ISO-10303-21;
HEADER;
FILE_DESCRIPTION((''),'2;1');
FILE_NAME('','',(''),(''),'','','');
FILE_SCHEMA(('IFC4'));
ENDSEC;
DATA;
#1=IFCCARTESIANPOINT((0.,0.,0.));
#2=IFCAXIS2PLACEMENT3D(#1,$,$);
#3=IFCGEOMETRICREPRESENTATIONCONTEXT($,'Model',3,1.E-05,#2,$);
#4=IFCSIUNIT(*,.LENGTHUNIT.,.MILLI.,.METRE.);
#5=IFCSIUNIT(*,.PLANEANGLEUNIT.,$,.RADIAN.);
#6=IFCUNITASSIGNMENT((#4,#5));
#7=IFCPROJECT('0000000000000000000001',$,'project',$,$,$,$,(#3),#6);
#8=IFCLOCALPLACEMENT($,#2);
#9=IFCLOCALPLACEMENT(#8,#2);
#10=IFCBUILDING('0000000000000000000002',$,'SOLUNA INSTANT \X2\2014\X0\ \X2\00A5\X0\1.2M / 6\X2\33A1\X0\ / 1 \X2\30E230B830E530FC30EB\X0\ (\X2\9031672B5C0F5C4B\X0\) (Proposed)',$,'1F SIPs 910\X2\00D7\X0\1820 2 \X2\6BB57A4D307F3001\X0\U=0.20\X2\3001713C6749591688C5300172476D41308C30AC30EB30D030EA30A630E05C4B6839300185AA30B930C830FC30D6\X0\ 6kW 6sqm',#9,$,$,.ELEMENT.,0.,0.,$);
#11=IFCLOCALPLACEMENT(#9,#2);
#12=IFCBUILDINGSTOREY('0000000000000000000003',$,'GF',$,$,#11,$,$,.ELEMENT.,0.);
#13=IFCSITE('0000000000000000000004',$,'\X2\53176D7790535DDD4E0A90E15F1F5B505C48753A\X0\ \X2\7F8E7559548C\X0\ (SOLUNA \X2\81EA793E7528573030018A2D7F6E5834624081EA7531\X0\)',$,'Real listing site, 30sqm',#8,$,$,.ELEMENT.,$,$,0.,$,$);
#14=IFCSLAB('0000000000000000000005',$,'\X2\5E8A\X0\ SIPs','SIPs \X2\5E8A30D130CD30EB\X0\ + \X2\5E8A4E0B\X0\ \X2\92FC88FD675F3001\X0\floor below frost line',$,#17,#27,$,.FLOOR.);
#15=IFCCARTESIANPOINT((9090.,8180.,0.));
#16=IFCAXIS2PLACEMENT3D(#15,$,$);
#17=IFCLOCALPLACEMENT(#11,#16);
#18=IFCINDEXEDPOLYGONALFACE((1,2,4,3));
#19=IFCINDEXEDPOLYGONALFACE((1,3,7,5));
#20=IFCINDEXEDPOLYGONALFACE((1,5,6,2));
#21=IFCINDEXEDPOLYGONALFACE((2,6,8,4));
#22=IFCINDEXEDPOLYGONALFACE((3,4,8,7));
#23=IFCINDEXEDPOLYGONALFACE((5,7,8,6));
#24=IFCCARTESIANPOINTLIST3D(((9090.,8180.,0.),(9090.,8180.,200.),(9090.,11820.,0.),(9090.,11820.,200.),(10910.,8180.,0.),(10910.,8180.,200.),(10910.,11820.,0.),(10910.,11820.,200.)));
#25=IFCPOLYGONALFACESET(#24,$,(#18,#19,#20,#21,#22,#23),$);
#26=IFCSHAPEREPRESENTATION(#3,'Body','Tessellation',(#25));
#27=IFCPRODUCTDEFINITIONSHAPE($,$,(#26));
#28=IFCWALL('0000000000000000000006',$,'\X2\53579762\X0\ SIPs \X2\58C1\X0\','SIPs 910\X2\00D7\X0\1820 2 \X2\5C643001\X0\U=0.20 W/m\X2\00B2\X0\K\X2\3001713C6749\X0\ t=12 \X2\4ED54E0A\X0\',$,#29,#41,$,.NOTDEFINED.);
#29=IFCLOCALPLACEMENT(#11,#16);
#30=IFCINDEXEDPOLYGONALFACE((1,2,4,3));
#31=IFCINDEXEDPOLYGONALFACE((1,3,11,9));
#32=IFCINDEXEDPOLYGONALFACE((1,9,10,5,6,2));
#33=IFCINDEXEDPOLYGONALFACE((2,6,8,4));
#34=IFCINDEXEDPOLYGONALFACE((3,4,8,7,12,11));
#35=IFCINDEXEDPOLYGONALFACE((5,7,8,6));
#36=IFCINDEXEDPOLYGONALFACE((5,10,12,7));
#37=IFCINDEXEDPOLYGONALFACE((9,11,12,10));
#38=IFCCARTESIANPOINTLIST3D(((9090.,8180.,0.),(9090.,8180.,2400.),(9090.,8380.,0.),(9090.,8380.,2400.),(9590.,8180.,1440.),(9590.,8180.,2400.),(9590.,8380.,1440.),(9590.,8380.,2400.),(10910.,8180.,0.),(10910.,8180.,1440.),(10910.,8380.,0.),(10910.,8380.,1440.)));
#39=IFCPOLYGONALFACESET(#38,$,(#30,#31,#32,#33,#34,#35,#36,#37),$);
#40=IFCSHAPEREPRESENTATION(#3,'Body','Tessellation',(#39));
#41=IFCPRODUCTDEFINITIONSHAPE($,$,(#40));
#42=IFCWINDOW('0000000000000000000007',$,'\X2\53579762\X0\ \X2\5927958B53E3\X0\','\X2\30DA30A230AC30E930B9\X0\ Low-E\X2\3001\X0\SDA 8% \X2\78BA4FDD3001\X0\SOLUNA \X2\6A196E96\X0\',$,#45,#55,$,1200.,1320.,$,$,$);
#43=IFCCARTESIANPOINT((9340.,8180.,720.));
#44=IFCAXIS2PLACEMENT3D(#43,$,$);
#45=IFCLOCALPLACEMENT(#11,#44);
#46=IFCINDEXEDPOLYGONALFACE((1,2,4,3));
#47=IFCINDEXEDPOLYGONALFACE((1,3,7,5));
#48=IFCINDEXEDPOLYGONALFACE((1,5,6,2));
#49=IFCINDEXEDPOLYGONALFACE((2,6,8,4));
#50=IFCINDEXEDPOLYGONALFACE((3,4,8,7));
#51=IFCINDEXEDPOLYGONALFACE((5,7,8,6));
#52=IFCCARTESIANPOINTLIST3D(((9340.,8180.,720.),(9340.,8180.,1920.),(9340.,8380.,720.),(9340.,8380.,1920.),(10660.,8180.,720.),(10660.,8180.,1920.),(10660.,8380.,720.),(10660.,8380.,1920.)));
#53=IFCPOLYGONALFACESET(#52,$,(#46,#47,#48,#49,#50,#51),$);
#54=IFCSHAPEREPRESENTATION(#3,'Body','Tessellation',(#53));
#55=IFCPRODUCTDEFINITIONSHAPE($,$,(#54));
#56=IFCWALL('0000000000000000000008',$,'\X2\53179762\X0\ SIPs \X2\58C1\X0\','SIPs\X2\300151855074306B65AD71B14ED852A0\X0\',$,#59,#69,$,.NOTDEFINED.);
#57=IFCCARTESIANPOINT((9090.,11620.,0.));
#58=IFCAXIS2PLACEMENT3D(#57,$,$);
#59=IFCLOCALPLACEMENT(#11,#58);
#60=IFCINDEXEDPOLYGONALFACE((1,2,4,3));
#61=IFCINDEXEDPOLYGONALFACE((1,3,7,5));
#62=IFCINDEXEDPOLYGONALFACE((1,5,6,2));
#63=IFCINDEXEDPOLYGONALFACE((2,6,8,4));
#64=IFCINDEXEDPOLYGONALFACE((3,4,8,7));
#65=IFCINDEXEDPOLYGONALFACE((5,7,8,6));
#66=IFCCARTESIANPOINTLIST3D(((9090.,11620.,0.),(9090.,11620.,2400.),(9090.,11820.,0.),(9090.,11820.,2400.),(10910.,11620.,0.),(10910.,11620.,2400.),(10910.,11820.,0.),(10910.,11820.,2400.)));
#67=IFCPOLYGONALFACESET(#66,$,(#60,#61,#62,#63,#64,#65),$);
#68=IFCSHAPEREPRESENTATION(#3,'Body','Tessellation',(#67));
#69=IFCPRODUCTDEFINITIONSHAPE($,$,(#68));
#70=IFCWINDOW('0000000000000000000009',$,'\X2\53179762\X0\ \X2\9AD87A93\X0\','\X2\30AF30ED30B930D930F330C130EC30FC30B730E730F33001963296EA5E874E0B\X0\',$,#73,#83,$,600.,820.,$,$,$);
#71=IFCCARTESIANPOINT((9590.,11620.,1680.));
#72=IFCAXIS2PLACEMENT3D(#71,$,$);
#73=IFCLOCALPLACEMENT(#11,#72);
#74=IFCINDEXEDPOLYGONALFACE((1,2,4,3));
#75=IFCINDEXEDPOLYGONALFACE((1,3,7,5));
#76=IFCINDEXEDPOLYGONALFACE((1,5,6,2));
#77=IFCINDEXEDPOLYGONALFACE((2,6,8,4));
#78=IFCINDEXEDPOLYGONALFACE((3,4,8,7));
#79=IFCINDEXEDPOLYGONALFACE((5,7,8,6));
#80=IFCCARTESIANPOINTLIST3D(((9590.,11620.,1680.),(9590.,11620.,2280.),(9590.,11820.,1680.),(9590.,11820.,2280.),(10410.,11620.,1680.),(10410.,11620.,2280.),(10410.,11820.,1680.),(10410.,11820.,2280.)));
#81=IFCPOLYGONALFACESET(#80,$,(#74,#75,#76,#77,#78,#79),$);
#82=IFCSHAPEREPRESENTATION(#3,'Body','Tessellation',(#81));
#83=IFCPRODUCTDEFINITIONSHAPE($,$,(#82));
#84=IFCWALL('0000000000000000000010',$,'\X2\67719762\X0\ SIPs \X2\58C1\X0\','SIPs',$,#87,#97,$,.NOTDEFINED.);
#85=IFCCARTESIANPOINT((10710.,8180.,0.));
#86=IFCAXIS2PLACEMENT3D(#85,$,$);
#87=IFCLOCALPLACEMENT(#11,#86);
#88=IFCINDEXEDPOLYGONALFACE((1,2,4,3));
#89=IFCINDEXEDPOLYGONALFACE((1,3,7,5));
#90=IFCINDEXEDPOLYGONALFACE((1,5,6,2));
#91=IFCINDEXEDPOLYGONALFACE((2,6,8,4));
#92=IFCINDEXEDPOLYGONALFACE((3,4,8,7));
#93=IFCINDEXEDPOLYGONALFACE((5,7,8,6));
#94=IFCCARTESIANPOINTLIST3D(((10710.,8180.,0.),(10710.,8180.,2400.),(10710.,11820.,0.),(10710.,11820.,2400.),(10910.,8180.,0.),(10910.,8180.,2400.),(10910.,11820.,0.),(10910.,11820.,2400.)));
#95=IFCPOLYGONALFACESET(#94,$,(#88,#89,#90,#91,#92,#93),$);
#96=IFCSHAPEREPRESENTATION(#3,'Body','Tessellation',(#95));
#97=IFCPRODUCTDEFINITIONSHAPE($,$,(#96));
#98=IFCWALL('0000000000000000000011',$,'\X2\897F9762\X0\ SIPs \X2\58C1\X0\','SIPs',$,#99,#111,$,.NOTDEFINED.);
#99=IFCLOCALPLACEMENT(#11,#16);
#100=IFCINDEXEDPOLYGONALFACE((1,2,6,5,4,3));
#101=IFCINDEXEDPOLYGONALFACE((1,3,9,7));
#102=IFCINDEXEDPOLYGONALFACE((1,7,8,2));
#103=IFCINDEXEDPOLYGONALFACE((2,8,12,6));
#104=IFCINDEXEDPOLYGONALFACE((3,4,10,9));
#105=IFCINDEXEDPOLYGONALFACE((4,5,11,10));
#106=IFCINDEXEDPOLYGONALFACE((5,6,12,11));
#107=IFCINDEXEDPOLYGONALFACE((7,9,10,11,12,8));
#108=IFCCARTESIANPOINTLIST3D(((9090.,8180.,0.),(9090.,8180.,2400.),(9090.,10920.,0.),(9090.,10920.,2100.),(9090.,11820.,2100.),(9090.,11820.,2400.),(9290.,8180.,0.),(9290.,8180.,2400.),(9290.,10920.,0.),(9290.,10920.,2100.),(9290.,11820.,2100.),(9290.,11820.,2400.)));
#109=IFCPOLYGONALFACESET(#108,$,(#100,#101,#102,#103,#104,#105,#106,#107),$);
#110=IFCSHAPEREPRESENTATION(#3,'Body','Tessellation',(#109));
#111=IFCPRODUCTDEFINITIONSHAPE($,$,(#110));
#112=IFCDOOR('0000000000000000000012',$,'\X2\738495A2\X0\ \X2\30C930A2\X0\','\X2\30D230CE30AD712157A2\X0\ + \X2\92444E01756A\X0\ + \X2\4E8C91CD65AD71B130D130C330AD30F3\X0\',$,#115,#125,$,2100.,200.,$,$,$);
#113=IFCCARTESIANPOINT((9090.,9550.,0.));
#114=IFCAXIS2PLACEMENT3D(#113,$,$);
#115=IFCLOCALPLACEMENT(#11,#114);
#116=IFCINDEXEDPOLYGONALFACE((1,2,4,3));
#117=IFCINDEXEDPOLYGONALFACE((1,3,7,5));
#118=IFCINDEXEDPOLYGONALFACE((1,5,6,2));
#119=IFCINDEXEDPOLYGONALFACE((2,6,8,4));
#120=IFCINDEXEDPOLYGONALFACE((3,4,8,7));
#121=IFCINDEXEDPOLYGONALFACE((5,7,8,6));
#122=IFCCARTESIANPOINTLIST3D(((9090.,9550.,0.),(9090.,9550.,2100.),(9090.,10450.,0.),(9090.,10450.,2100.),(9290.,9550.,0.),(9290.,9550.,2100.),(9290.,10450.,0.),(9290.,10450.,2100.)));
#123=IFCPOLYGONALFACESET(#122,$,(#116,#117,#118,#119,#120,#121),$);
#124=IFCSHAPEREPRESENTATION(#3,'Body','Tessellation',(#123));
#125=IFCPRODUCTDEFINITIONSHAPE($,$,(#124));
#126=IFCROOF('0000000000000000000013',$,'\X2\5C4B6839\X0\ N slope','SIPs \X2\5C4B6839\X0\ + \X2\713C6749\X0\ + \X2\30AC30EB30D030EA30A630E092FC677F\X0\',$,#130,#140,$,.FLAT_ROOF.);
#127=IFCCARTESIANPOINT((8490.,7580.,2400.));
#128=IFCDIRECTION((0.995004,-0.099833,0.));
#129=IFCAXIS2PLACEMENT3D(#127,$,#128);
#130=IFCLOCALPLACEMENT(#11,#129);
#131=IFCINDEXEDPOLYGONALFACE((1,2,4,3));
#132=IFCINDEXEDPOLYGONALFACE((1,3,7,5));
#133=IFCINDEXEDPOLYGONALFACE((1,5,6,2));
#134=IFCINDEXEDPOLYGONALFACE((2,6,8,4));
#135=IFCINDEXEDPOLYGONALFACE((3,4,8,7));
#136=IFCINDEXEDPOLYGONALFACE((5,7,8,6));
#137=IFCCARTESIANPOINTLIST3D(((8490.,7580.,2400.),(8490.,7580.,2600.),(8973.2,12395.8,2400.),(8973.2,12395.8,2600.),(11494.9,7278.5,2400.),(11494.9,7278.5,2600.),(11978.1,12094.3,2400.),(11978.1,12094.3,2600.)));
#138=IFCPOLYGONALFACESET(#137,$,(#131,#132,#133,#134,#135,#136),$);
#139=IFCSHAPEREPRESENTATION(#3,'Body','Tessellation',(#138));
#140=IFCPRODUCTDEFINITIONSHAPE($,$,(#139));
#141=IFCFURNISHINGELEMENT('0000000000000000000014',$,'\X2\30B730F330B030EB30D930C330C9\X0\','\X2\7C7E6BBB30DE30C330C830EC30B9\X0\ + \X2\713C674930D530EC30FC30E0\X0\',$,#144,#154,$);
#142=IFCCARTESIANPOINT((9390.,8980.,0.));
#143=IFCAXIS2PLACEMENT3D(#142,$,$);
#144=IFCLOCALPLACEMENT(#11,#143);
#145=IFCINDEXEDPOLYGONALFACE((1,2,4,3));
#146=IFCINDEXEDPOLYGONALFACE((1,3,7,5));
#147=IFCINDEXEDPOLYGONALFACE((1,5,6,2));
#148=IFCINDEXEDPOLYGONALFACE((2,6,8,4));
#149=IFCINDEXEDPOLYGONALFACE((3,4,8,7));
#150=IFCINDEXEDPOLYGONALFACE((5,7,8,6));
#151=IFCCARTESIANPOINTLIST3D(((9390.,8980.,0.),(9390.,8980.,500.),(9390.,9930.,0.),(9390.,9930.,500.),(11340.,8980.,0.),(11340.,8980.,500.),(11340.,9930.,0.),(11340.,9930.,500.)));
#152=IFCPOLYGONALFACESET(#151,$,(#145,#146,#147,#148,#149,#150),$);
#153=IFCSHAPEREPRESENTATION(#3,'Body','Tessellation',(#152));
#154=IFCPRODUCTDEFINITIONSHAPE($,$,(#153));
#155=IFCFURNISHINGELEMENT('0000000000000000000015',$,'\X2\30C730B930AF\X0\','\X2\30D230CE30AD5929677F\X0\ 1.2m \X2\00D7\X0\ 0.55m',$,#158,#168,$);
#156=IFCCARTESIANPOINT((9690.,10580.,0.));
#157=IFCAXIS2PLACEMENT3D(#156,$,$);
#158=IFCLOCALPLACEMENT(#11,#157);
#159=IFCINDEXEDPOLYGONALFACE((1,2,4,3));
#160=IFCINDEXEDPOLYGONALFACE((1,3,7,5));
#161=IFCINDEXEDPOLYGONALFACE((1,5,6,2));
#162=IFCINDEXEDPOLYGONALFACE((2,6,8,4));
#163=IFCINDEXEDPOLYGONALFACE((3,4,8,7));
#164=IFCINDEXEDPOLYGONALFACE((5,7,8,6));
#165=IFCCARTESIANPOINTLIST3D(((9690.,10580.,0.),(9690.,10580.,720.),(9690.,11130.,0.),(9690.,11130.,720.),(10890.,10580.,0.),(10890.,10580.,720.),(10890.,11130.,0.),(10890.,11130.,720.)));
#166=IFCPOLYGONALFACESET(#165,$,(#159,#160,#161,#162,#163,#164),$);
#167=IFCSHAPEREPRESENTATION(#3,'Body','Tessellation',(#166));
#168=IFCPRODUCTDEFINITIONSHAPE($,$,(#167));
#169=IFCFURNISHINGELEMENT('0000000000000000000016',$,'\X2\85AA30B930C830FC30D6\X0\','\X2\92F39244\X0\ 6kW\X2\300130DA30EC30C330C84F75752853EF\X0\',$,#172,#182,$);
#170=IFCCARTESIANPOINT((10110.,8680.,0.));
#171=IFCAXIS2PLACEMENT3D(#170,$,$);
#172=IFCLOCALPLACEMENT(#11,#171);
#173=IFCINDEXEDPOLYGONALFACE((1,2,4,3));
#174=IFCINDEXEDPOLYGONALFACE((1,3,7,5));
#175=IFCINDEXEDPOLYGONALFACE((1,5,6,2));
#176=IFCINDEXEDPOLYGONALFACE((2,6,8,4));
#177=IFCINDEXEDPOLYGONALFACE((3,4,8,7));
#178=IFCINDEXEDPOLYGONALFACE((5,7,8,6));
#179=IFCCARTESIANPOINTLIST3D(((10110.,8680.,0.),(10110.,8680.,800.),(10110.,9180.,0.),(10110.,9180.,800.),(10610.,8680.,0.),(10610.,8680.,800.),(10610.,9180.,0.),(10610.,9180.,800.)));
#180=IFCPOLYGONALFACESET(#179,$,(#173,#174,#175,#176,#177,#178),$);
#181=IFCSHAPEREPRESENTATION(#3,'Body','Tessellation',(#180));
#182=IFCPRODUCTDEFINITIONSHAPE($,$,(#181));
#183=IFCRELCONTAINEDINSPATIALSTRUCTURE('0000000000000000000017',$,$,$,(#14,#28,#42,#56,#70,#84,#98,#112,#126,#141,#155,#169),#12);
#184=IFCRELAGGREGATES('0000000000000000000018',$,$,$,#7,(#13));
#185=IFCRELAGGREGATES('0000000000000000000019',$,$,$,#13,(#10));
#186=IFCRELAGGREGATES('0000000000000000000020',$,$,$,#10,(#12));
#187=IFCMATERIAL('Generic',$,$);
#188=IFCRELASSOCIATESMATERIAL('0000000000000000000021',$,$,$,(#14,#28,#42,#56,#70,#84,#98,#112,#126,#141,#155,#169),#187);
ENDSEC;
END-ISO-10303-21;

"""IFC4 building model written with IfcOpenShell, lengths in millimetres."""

from ifc_helpers import new_model, si_unit, frame, frame_2d, origin, place, context, project, spatial, rectangle, extrude, material, element, fill, save


model = new_model("IFC4")

# Units and contexts
model_context = context("Model", 3, precision=1e-05, world=origin())
ifc_project = project(units=[si_unit("LENGTHUNIT", "METRE", prefix="MILLI"), si_unit("PLANEANGLEUNIT", "RADIAN")], contexts=[model_context])

# Site, building, storey
site_placement = place(None, origin())
site = spatial("IfcSite", under=ifc_project, at=site_placement, Name="北海道川上郡弟子屈町 美留和 (SOLUNA 自社用地、設置場所自由)", ObjectType="Real listing site, 30sqm", CompositionType="ELEMENT", RefElevation=0.0)
building_placement = place(site_placement, origin())
building = spatial("IfcBuilding", under=site, at=building_placement, Name="SOLUNA INSTANT — ¥1.2M / 6㎡ / 1 モジュール (週末小屋) (Proposed)", ObjectType="1F SIPs 910×1820 2 段積み、U=0.20、焼杉外装、片流れガルバリウム屋根、薪ストーブ 6kW 6sqm", CompositionType="ELEMENT", ElevationOfRefHeight=0.0, ElevationOfTerrain=0.0)
storey_placement = place(building_placement, origin())
storey = spatial("IfcBuildingStorey", under=building, at=storey_placement, Name="GF", CompositionType="ELEMENT", Elevation=0.0)

# Slab
ifc_material = material(Name="Generic")
slab_placement = place(storey_placement, frame((9090.0, 8180.0, 0.0)))
element("IfcSlab", 1, at=slab_placement, inside=storey, material=ifc_material, Name="床 SIPs", Description="SIPs 床パネル + 床下 鋼製束、floor below frost line", PredefinedType="FLOOR", context=model_context, shape_type="SweptSolid", body=[
    extrude(rectangle(XDim=1820.0, YDim=3640.0, at=frame_2d((910.0, 1820.0))), frame((9090.0, 8180.0, 0.0)), (0.0, 0.0, 1.0), 200.0),
])

# Walls, openings, windows
wall_1_placement = place(storey_placement, frame((9090.0, 8180.0, 0.0)))
wall_1 = element("IfcWall", 2, at=wall_1_placement, inside=storey, material=ifc_material, Name="南面 SIPs 壁", Description="SIPs 910×1820 2 層、U=0.20 W/m²K、焼杉 t=12 仕上", PredefinedType="NOTDEFINED", context=model_context, shape_type="SweptSolid", body=[
    extrude(rectangle(XDim=1820.0, YDim=200.0, at=frame_2d((910.0, 100.0))), frame((9090.0, 8180.0, 0.0)), (0.0, 0.0, 1.0), 2400.0),
])
opening_1_placement = place(storey_placement, frame((9340.0, 8180.0, 720.0)))
opening_1 = element("IfcOpeningElement", 3, at=opening_1_placement, cuts=wall_1, PredefinedType="NOTDEFINED", context=model_context, shape_type="SweptSolid", body=[
    extrude(rectangle(XDim=1320.0, YDim=200.0, at=frame_2d((660.0, 100.0))), frame((9340.0, 8180.0, 720.0)), (0.0, 0.0, 1.0), 1200.0),
])
window_1_placement = place(storey_placement, frame((9340.0, 8180.0, 720.0)))
window_1 = element("IfcWindow", 4, at=window_1_placement, inside=storey, material=ifc_material, Name="南面 大開口", Description="ペアガラス Low-E、SDA 8% 確保、SOLUNA 標準", OverallHeight=1200.0, OverallWidth=1320.0, context=model_context, shape_type="SweptSolid", body=[
    extrude(rectangle(XDim=1320.0, YDim=200.0, at=frame_2d((660.0, 100.0))), frame((9340.0, 8180.0, 720.0)), (0.0, 0.0, 1.0), 1200.0),
])
fill(opening_1, window_1)
wall_2_placement = place(storey_placement, frame((9090.0, 11620.0, 0.0)))
wall_2 = element("IfcWall", 5, at=wall_2_placement, inside=storey, material=ifc_material, Name="北面 SIPs 壁", Description="SIPs、内側に断熱付加", PredefinedType="NOTDEFINED", context=model_context, shape_type="SweptSolid", body=[
    extrude(rectangle(XDim=1820.0, YDim=200.0, at=frame_2d((910.0, 100.0))), frame((9090.0, 11620.0, 0.0)), (0.0, 0.0, 1.0), 2400.0),
])
opening_2_placement = place(storey_placement, frame((9590.0, 11620.0, 1680.0)))
opening_2 = element("IfcOpeningElement", 6, at=opening_2_placement, cuts=wall_2, PredefinedType="NOTDEFINED", context=model_context, shape_type="SweptSolid", body=[
    extrude(rectangle(XDim=820.0, YDim=200.0, at=frame_2d((410.0, 100.0))), frame((9590.0, 11620.0, 1680.0)), (0.0, 0.0, 1.0), 600.0),
])
window_2_placement = place(storey_placement, frame((9590.0, 11620.0, 1680.0)))
window_2 = element("IfcWindow", 7, at=window_2_placement, inside=storey, material=ifc_material, Name="北面 高窓", Description="クロスベンチレーション、防雪庇下", OverallHeight=600.0, OverallWidth=820.0, context=model_context, shape_type="SweptSolid", body=[
    extrude(rectangle(XDim=820.0, YDim=200.0, at=frame_2d((410.0, 100.0))), frame((9590.0, 11620.0, 1680.0)), (0.0, 0.0, 1.0), 600.0),
])
fill(opening_2, window_2)

# Wall
wall_3_placement = place(storey_placement, frame((10710.0, 8180.0, 0.0)))
element("IfcWall", 8, at=wall_3_placement, inside=storey, material=ifc_material, Name="東面 SIPs 壁", Description="SIPs", PredefinedType="NOTDEFINED", context=model_context, shape_type="SweptSolid", body=[
    extrude(rectangle(XDim=200.0, YDim=3640.0, at=frame_2d((100.0, 1820.0))), frame((10710.0, 8180.0, 0.0)), (0.0, 0.0, 1.0), 2400.0),
])

# Wall, opening, door
wall_4_placement = place(storey_placement, frame((9090.0, 8180.0, 0.0)))
wall_4 = element("IfcWall", 9, at=wall_4_placement, inside=storey, material=ifc_material, Name="西面 SIPs 壁", Description="SIPs", PredefinedType="NOTDEFINED", context=model_context, shape_type="SweptSolid", body=[
    extrude(rectangle(XDim=200.0, YDim=3640.0, at=frame_2d((100.0, 1820.0))), frame((9090.0, 8180.0, 0.0)), (0.0, 0.0, 1.0), 2400.0),
])
opening_3_placement = place(storey_placement, frame((9090.0, 9550.0, 0.0)))
opening_3 = element("IfcOpeningElement", 10, at=opening_3_placement, cuts=wall_4, PredefinedType="NOTDEFINED", context=model_context, shape_type="SweptSolid", body=[
    extrude(rectangle(XDim=200.0, YDim=900.0, at=frame_2d((100.0, 450.0))), frame((9090.0, 9550.0, 0.0)), (0.0, 0.0, 1.0), 2100.0),
])
door_placement = place(storey_placement, frame((9090.0, 9550.0, 0.0)))
door = element("IfcDoor", 11, at=door_placement, inside=storey, material=ifc_material, Name="玄関 ドア", Description="ヒノキ無垢 + 鉄丁番 + 二重断熱パッキン", OverallHeight=2100.0, OverallWidth=200.0, context=model_context, shape_type="SweptSolid", body=[
    extrude(rectangle(XDim=200.0, YDim=900.0, at=frame_2d((100.0, 450.0))), frame((9090.0, 9550.0, 0.0)), (0.0, 0.0, 1.0), 2100.0),
])
fill(opening_3, door)

# Roof
roof_placement = place(storey_placement, frame((8490.0, 7580.0, 2400.0), x_axis=(0.995004, -0.099833, 0.0)))
element("IfcRoof", 12, at=roof_placement, inside=storey, material=ifc_material, Name="屋根 N slope", Description="SIPs 屋根 + 焼杉 + ガルバリウム鋼板", PredefinedType="FLAT_ROOF", context=model_context, shape_type="SweptSolid", body=[
    extrude(rectangle(XDim=3020.0, YDim=4840.0, at=frame_2d((1510.0, 2420.0))), frame((8490.0, 7580.0, 2400.0), x_axis=(0.995004, -0.099833, 0.0)), (0.0, 0.0, 1.0), 200.0),
])

# Furnishing elements
furnishing_1_placement = place(storey_placement, frame((9390.0, 8980.0, 0.0)))
element("IfcFurnishingElement", 13, at=furnishing_1_placement, inside=storey, material=ifc_material, Name="シングルベッド", Description="籾殻マットレス + 焼杉フレーム", context=model_context, shape_type="SweptSolid", body=[
    extrude(rectangle(XDim=1950.0, YDim=950.0, at=frame_2d((975.0, 475.0))), frame((9390.0, 8980.0, 0.0)), (0.0, 0.0, 1.0), 500.0),
])
furnishing_2_placement = place(storey_placement, frame((9690.0, 10580.0, 0.0)))
element("IfcFurnishingElement", 14, at=furnishing_2_placement, inside=storey, material=ifc_material, Name="デスク", Description="ヒノキ天板 1.2m × 0.55m", context=model_context, shape_type="SweptSolid", body=[
    extrude(rectangle(XDim=1200.0, YDim=550.0, at=frame_2d((600.0, 275.0))), frame((9690.0, 10580.0, 0.0)), (0.0, 0.0, 1.0), 720.0),
])
furnishing_3_placement = place(storey_placement, frame((10110.0, 8680.0, 0.0)))
element("IfcFurnishingElement", 15, at=furnishing_3_placement, inside=storey, material=ifc_material, Name="薪ストーブ", Description="鋳鉄 6kW、ペレット併用可", context=model_context, shape_type="SweptSolid", body=[
    extrude(rectangle(XDim=500.0, YDim=500.0, at=frame_2d((250.0, 250.0))), frame((10110.0, 8680.0, 0.0)), (0.0, 0.0, 1.0), 800.0),
])

save(model, "model.ifc")
